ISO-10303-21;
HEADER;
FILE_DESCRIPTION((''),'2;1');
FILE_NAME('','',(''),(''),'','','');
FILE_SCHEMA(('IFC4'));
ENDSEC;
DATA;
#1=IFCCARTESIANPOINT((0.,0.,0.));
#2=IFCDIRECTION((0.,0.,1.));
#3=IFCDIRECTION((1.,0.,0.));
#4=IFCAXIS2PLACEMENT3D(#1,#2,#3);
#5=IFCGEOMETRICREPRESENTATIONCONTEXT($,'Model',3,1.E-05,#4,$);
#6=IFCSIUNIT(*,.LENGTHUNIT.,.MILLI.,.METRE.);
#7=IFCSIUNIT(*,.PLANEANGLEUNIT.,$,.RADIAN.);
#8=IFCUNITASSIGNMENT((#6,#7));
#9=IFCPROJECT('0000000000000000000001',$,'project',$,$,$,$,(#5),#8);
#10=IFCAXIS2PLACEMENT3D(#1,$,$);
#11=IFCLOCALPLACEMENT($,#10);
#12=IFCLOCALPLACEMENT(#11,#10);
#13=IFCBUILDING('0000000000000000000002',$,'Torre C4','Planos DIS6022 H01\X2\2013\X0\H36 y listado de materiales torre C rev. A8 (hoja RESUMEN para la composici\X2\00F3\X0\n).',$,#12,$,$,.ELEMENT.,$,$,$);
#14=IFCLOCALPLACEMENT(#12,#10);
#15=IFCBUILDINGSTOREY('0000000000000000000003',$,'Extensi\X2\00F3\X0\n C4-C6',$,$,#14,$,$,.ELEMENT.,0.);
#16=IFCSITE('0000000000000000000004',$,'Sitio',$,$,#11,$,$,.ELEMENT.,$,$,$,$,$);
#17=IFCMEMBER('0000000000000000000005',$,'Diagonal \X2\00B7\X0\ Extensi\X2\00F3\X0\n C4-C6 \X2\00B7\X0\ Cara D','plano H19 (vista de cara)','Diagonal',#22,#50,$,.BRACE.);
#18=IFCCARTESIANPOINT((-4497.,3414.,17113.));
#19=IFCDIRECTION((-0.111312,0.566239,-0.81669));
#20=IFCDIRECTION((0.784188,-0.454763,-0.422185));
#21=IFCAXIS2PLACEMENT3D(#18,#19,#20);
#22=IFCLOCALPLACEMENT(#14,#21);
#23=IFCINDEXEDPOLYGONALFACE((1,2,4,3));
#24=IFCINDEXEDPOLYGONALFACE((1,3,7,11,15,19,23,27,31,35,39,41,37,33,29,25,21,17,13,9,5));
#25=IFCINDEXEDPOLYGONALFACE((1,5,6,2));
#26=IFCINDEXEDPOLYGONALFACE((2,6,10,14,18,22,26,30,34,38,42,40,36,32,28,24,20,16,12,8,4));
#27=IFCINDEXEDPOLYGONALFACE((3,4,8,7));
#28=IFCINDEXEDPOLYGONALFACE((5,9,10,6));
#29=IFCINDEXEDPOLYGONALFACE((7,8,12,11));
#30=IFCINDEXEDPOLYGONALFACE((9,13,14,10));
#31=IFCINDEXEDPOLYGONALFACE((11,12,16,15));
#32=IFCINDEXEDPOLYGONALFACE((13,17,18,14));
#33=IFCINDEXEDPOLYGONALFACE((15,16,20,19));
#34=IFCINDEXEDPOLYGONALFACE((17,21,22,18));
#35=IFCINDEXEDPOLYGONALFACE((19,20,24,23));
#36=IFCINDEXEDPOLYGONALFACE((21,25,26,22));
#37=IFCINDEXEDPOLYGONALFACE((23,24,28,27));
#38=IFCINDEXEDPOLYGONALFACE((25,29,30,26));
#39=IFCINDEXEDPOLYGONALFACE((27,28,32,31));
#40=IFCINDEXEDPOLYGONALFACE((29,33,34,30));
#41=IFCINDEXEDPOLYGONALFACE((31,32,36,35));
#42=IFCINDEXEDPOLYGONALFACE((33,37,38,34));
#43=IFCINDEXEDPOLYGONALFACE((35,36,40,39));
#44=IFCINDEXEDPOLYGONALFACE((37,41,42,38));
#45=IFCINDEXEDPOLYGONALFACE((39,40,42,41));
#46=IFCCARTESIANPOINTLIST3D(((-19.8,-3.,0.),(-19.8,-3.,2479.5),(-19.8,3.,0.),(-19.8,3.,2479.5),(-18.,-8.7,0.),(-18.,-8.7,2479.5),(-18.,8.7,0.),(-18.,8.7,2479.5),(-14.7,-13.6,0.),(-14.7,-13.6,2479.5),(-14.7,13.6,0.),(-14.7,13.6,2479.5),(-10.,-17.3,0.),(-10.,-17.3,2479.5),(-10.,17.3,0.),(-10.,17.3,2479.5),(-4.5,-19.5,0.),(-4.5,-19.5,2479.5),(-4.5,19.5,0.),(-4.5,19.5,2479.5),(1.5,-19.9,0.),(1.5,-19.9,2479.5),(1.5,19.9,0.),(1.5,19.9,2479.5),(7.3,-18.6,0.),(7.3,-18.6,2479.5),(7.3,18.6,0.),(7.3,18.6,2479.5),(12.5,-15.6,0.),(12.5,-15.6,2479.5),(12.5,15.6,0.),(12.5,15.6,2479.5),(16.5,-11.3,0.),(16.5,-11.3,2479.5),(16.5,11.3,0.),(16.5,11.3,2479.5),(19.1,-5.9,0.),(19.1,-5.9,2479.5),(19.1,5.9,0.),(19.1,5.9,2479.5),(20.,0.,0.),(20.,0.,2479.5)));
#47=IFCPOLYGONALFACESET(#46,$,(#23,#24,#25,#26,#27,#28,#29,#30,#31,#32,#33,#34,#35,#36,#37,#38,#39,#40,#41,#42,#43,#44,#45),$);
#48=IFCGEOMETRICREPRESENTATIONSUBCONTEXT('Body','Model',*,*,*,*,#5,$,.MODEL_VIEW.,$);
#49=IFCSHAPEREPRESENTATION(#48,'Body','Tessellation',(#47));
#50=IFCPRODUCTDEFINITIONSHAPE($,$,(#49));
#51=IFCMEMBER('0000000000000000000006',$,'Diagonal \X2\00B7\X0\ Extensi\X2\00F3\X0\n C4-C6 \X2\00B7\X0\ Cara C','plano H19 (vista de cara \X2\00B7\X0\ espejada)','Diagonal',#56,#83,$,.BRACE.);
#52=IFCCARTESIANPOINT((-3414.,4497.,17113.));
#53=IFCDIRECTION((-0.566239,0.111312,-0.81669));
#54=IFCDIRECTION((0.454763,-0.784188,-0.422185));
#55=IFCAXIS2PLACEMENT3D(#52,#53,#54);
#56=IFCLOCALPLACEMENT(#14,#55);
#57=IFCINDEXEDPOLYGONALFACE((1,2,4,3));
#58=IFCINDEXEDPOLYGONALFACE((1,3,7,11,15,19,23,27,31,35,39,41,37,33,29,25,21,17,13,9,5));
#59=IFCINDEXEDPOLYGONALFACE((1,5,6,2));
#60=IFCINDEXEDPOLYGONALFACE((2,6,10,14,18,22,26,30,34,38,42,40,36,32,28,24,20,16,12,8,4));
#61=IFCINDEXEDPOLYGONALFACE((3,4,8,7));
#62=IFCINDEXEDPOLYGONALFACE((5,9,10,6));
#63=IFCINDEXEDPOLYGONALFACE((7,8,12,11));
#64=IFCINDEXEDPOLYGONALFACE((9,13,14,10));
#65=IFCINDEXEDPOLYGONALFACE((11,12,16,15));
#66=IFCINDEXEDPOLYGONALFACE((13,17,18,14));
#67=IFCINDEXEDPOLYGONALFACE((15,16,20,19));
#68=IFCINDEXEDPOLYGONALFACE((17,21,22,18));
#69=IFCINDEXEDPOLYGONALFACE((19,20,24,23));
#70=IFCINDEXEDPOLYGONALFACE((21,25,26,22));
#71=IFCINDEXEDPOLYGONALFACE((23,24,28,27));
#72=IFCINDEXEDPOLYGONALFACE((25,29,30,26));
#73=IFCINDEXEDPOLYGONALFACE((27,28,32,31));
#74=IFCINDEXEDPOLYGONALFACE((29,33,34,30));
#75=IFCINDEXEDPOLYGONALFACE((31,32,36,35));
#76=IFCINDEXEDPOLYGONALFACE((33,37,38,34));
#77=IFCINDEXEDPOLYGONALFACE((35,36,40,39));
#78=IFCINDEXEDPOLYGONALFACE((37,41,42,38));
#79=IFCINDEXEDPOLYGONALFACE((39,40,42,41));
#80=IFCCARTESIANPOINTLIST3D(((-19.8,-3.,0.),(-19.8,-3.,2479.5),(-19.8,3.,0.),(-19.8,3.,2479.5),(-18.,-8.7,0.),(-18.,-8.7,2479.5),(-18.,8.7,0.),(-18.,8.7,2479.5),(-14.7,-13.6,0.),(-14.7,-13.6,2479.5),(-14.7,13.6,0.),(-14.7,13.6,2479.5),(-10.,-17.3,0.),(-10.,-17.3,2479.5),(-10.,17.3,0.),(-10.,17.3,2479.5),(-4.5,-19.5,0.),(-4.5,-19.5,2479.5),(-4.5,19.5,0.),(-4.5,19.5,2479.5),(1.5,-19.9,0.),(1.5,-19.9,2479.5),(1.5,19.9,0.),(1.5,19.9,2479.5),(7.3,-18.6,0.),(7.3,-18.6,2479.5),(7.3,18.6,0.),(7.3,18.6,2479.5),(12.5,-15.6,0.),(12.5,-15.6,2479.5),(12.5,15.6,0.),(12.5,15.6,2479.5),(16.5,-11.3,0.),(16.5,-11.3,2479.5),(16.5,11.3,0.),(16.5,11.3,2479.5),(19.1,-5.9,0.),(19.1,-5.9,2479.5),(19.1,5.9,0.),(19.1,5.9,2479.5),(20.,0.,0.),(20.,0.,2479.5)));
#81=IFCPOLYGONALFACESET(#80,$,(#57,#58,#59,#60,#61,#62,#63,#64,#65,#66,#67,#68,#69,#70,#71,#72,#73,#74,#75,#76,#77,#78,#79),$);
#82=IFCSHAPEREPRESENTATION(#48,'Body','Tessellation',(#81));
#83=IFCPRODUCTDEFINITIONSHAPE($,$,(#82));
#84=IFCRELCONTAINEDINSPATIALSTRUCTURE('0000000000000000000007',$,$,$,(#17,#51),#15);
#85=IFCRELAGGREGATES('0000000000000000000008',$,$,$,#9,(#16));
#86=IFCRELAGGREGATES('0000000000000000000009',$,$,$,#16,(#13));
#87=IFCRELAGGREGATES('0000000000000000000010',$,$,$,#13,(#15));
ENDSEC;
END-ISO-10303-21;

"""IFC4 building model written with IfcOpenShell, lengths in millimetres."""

from ifc_helpers import new_model, si_unit, frame, origin, origin_with_axes, place, context, subcontext, project, spatial, circle, extrude, element, save


model = new_model("IFC4")

# Units and contexts
model_context = context("Model", 3, precision=1e-05, world=origin_with_axes())
body_context = subcontext(model_context, "Body", "Model", "MODEL_VIEW")
ifc_project = project(units=[si_unit("LENGTHUNIT", "METRE", prefix="MILLI"), si_unit("PLANEANGLEUNIT", "RADIAN")], contexts=[model_context])

# Site, building, storey
site_placement = place(None, origin())
site = spatial("IfcSite", under=ifc_project, at=site_placement, Name="Sitio", CompositionType="ELEMENT")
building_placement = place(site_placement, origin())
building = spatial("IfcBuilding", under=site, at=building_placement, Name="Torre C4", Description="Planos DIS6022 H01–H36 y listado de materiales torre C rev. A8 (hoja RESUMEN para la composición).", CompositionType="ELEMENT")
storey_placement = place(building_placement, origin())
storey = spatial("IfcBuildingStorey", under=building, at=storey_placement, Name="Extensión C4-C6", CompositionType="ELEMENT", Elevation=0.0)

# Members
for number, where, z_axis, x_axis, name, description in (
    (1, (-4497.0, 3414.0, 17113.0), (-0.111312, 0.566239, -0.81669), (0.784188, -0.454763, -0.422185), "Diagonal · Extensión C4-C6 · Cara D", "plano H19 (vista de cara)"),
    (2, (-3414.0, 4497.0, 17113.0), (-0.566239, 0.111312, -0.81669), (0.454763, -0.784188, -0.422185), "Diagonal · Extensión C4-C6 · Cara C", "plano H19 (vista de cara · espejada)"),
):
    element("IfcMember", number, at=place(storey_placement, frame(where, z_axis=z_axis, x_axis=x_axis)), inside=storey, Name=name, Description=description, ObjectType="Diagonal", PredefinedType="BRACE", context=body_context, shape_type="SweptSolid", body=[
        extrude(circle(Radius=20.0), None, (0.0, 0.0, 1.0), 2479.5),
    ])

save(model, "model.ifc")
